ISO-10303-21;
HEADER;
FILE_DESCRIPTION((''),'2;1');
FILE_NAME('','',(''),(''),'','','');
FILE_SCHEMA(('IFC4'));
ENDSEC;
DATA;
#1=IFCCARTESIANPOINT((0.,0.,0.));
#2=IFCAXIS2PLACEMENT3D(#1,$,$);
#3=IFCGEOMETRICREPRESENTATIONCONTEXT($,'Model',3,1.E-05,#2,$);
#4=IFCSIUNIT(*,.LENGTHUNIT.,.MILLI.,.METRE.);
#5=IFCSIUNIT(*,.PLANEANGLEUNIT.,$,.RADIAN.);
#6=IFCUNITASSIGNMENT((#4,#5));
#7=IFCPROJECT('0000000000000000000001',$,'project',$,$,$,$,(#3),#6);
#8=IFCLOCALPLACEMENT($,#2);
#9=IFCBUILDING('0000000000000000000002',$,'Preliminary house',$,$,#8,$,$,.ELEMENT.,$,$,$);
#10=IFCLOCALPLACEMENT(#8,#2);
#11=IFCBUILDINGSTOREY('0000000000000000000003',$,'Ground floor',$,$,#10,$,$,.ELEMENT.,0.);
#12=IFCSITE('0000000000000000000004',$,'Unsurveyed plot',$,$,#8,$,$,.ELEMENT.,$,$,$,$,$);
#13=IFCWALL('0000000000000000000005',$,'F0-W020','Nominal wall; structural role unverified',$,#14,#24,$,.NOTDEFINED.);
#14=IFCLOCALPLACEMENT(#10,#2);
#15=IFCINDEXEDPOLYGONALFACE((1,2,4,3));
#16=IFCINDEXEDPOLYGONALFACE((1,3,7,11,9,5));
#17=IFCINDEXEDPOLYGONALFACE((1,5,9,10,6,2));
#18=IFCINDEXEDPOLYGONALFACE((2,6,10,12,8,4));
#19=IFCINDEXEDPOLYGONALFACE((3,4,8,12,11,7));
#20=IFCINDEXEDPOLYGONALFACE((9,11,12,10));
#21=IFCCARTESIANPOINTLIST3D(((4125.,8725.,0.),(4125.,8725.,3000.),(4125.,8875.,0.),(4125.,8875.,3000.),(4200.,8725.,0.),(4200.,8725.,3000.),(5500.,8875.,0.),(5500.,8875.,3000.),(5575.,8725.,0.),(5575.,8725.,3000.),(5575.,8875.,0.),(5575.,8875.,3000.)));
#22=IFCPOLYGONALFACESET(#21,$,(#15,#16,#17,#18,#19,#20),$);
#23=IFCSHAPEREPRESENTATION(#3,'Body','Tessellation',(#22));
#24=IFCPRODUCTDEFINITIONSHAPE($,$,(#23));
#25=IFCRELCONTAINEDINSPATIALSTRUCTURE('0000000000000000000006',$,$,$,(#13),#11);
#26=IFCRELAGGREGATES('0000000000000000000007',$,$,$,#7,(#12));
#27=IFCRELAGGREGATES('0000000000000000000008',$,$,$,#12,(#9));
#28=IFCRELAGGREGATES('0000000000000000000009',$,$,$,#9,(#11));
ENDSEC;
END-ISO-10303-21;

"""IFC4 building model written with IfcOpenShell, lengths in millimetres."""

from ifc_helpers import new_model, si_unit, origin, place, context, project, spatial, polyline, outline, extrude, element, save


model = new_model("IFC4")

# Units and contexts
model_context = context("Model", 3, precision=1e-05, world=origin())
ifc_project = project(units=[si_unit("LENGTHUNIT", "METRE", prefix="MILLI"), si_unit("PLANEANGLEUNIT", "RADIAN")], contexts=[model_context])

# Site, building, storey
placement_1 = place(None, origin())
site = spatial("IfcSite", under=ifc_project, at=placement_1, Name="Unsurveyed plot", CompositionType="ELEMENT")
building = spatial("IfcBuilding", under=site, at=placement_1, Name="Preliminary house", CompositionType="ELEMENT")
placement_2 = place(placement_1, origin())
storey = spatial("IfcBuildingStorey", under=building, at=placement_2, Name="Ground floor", CompositionType="ELEMENT", Elevation=0.0)

# Wall
element("IfcWall", 1, at=placement_2, inside=storey, Name="F0-W020", Description="Nominal wall; structural role unverified", PredefinedType="NOTDEFINED", context=model_context, shape_type="SweptSolid", body=[
    extrude(outline(polyline([(5575.0, 8875.0), (5575.0, 8725.0), (4200.0, 8725.0), (4125.0, 8725.0), (4125.0, 8875.0), (5500.0, 8875.0), (5575.0, 8875.0)])), origin(), (0.0, 0.0, 1.0), 3000.0),
])

save(model, "model.ifc")
